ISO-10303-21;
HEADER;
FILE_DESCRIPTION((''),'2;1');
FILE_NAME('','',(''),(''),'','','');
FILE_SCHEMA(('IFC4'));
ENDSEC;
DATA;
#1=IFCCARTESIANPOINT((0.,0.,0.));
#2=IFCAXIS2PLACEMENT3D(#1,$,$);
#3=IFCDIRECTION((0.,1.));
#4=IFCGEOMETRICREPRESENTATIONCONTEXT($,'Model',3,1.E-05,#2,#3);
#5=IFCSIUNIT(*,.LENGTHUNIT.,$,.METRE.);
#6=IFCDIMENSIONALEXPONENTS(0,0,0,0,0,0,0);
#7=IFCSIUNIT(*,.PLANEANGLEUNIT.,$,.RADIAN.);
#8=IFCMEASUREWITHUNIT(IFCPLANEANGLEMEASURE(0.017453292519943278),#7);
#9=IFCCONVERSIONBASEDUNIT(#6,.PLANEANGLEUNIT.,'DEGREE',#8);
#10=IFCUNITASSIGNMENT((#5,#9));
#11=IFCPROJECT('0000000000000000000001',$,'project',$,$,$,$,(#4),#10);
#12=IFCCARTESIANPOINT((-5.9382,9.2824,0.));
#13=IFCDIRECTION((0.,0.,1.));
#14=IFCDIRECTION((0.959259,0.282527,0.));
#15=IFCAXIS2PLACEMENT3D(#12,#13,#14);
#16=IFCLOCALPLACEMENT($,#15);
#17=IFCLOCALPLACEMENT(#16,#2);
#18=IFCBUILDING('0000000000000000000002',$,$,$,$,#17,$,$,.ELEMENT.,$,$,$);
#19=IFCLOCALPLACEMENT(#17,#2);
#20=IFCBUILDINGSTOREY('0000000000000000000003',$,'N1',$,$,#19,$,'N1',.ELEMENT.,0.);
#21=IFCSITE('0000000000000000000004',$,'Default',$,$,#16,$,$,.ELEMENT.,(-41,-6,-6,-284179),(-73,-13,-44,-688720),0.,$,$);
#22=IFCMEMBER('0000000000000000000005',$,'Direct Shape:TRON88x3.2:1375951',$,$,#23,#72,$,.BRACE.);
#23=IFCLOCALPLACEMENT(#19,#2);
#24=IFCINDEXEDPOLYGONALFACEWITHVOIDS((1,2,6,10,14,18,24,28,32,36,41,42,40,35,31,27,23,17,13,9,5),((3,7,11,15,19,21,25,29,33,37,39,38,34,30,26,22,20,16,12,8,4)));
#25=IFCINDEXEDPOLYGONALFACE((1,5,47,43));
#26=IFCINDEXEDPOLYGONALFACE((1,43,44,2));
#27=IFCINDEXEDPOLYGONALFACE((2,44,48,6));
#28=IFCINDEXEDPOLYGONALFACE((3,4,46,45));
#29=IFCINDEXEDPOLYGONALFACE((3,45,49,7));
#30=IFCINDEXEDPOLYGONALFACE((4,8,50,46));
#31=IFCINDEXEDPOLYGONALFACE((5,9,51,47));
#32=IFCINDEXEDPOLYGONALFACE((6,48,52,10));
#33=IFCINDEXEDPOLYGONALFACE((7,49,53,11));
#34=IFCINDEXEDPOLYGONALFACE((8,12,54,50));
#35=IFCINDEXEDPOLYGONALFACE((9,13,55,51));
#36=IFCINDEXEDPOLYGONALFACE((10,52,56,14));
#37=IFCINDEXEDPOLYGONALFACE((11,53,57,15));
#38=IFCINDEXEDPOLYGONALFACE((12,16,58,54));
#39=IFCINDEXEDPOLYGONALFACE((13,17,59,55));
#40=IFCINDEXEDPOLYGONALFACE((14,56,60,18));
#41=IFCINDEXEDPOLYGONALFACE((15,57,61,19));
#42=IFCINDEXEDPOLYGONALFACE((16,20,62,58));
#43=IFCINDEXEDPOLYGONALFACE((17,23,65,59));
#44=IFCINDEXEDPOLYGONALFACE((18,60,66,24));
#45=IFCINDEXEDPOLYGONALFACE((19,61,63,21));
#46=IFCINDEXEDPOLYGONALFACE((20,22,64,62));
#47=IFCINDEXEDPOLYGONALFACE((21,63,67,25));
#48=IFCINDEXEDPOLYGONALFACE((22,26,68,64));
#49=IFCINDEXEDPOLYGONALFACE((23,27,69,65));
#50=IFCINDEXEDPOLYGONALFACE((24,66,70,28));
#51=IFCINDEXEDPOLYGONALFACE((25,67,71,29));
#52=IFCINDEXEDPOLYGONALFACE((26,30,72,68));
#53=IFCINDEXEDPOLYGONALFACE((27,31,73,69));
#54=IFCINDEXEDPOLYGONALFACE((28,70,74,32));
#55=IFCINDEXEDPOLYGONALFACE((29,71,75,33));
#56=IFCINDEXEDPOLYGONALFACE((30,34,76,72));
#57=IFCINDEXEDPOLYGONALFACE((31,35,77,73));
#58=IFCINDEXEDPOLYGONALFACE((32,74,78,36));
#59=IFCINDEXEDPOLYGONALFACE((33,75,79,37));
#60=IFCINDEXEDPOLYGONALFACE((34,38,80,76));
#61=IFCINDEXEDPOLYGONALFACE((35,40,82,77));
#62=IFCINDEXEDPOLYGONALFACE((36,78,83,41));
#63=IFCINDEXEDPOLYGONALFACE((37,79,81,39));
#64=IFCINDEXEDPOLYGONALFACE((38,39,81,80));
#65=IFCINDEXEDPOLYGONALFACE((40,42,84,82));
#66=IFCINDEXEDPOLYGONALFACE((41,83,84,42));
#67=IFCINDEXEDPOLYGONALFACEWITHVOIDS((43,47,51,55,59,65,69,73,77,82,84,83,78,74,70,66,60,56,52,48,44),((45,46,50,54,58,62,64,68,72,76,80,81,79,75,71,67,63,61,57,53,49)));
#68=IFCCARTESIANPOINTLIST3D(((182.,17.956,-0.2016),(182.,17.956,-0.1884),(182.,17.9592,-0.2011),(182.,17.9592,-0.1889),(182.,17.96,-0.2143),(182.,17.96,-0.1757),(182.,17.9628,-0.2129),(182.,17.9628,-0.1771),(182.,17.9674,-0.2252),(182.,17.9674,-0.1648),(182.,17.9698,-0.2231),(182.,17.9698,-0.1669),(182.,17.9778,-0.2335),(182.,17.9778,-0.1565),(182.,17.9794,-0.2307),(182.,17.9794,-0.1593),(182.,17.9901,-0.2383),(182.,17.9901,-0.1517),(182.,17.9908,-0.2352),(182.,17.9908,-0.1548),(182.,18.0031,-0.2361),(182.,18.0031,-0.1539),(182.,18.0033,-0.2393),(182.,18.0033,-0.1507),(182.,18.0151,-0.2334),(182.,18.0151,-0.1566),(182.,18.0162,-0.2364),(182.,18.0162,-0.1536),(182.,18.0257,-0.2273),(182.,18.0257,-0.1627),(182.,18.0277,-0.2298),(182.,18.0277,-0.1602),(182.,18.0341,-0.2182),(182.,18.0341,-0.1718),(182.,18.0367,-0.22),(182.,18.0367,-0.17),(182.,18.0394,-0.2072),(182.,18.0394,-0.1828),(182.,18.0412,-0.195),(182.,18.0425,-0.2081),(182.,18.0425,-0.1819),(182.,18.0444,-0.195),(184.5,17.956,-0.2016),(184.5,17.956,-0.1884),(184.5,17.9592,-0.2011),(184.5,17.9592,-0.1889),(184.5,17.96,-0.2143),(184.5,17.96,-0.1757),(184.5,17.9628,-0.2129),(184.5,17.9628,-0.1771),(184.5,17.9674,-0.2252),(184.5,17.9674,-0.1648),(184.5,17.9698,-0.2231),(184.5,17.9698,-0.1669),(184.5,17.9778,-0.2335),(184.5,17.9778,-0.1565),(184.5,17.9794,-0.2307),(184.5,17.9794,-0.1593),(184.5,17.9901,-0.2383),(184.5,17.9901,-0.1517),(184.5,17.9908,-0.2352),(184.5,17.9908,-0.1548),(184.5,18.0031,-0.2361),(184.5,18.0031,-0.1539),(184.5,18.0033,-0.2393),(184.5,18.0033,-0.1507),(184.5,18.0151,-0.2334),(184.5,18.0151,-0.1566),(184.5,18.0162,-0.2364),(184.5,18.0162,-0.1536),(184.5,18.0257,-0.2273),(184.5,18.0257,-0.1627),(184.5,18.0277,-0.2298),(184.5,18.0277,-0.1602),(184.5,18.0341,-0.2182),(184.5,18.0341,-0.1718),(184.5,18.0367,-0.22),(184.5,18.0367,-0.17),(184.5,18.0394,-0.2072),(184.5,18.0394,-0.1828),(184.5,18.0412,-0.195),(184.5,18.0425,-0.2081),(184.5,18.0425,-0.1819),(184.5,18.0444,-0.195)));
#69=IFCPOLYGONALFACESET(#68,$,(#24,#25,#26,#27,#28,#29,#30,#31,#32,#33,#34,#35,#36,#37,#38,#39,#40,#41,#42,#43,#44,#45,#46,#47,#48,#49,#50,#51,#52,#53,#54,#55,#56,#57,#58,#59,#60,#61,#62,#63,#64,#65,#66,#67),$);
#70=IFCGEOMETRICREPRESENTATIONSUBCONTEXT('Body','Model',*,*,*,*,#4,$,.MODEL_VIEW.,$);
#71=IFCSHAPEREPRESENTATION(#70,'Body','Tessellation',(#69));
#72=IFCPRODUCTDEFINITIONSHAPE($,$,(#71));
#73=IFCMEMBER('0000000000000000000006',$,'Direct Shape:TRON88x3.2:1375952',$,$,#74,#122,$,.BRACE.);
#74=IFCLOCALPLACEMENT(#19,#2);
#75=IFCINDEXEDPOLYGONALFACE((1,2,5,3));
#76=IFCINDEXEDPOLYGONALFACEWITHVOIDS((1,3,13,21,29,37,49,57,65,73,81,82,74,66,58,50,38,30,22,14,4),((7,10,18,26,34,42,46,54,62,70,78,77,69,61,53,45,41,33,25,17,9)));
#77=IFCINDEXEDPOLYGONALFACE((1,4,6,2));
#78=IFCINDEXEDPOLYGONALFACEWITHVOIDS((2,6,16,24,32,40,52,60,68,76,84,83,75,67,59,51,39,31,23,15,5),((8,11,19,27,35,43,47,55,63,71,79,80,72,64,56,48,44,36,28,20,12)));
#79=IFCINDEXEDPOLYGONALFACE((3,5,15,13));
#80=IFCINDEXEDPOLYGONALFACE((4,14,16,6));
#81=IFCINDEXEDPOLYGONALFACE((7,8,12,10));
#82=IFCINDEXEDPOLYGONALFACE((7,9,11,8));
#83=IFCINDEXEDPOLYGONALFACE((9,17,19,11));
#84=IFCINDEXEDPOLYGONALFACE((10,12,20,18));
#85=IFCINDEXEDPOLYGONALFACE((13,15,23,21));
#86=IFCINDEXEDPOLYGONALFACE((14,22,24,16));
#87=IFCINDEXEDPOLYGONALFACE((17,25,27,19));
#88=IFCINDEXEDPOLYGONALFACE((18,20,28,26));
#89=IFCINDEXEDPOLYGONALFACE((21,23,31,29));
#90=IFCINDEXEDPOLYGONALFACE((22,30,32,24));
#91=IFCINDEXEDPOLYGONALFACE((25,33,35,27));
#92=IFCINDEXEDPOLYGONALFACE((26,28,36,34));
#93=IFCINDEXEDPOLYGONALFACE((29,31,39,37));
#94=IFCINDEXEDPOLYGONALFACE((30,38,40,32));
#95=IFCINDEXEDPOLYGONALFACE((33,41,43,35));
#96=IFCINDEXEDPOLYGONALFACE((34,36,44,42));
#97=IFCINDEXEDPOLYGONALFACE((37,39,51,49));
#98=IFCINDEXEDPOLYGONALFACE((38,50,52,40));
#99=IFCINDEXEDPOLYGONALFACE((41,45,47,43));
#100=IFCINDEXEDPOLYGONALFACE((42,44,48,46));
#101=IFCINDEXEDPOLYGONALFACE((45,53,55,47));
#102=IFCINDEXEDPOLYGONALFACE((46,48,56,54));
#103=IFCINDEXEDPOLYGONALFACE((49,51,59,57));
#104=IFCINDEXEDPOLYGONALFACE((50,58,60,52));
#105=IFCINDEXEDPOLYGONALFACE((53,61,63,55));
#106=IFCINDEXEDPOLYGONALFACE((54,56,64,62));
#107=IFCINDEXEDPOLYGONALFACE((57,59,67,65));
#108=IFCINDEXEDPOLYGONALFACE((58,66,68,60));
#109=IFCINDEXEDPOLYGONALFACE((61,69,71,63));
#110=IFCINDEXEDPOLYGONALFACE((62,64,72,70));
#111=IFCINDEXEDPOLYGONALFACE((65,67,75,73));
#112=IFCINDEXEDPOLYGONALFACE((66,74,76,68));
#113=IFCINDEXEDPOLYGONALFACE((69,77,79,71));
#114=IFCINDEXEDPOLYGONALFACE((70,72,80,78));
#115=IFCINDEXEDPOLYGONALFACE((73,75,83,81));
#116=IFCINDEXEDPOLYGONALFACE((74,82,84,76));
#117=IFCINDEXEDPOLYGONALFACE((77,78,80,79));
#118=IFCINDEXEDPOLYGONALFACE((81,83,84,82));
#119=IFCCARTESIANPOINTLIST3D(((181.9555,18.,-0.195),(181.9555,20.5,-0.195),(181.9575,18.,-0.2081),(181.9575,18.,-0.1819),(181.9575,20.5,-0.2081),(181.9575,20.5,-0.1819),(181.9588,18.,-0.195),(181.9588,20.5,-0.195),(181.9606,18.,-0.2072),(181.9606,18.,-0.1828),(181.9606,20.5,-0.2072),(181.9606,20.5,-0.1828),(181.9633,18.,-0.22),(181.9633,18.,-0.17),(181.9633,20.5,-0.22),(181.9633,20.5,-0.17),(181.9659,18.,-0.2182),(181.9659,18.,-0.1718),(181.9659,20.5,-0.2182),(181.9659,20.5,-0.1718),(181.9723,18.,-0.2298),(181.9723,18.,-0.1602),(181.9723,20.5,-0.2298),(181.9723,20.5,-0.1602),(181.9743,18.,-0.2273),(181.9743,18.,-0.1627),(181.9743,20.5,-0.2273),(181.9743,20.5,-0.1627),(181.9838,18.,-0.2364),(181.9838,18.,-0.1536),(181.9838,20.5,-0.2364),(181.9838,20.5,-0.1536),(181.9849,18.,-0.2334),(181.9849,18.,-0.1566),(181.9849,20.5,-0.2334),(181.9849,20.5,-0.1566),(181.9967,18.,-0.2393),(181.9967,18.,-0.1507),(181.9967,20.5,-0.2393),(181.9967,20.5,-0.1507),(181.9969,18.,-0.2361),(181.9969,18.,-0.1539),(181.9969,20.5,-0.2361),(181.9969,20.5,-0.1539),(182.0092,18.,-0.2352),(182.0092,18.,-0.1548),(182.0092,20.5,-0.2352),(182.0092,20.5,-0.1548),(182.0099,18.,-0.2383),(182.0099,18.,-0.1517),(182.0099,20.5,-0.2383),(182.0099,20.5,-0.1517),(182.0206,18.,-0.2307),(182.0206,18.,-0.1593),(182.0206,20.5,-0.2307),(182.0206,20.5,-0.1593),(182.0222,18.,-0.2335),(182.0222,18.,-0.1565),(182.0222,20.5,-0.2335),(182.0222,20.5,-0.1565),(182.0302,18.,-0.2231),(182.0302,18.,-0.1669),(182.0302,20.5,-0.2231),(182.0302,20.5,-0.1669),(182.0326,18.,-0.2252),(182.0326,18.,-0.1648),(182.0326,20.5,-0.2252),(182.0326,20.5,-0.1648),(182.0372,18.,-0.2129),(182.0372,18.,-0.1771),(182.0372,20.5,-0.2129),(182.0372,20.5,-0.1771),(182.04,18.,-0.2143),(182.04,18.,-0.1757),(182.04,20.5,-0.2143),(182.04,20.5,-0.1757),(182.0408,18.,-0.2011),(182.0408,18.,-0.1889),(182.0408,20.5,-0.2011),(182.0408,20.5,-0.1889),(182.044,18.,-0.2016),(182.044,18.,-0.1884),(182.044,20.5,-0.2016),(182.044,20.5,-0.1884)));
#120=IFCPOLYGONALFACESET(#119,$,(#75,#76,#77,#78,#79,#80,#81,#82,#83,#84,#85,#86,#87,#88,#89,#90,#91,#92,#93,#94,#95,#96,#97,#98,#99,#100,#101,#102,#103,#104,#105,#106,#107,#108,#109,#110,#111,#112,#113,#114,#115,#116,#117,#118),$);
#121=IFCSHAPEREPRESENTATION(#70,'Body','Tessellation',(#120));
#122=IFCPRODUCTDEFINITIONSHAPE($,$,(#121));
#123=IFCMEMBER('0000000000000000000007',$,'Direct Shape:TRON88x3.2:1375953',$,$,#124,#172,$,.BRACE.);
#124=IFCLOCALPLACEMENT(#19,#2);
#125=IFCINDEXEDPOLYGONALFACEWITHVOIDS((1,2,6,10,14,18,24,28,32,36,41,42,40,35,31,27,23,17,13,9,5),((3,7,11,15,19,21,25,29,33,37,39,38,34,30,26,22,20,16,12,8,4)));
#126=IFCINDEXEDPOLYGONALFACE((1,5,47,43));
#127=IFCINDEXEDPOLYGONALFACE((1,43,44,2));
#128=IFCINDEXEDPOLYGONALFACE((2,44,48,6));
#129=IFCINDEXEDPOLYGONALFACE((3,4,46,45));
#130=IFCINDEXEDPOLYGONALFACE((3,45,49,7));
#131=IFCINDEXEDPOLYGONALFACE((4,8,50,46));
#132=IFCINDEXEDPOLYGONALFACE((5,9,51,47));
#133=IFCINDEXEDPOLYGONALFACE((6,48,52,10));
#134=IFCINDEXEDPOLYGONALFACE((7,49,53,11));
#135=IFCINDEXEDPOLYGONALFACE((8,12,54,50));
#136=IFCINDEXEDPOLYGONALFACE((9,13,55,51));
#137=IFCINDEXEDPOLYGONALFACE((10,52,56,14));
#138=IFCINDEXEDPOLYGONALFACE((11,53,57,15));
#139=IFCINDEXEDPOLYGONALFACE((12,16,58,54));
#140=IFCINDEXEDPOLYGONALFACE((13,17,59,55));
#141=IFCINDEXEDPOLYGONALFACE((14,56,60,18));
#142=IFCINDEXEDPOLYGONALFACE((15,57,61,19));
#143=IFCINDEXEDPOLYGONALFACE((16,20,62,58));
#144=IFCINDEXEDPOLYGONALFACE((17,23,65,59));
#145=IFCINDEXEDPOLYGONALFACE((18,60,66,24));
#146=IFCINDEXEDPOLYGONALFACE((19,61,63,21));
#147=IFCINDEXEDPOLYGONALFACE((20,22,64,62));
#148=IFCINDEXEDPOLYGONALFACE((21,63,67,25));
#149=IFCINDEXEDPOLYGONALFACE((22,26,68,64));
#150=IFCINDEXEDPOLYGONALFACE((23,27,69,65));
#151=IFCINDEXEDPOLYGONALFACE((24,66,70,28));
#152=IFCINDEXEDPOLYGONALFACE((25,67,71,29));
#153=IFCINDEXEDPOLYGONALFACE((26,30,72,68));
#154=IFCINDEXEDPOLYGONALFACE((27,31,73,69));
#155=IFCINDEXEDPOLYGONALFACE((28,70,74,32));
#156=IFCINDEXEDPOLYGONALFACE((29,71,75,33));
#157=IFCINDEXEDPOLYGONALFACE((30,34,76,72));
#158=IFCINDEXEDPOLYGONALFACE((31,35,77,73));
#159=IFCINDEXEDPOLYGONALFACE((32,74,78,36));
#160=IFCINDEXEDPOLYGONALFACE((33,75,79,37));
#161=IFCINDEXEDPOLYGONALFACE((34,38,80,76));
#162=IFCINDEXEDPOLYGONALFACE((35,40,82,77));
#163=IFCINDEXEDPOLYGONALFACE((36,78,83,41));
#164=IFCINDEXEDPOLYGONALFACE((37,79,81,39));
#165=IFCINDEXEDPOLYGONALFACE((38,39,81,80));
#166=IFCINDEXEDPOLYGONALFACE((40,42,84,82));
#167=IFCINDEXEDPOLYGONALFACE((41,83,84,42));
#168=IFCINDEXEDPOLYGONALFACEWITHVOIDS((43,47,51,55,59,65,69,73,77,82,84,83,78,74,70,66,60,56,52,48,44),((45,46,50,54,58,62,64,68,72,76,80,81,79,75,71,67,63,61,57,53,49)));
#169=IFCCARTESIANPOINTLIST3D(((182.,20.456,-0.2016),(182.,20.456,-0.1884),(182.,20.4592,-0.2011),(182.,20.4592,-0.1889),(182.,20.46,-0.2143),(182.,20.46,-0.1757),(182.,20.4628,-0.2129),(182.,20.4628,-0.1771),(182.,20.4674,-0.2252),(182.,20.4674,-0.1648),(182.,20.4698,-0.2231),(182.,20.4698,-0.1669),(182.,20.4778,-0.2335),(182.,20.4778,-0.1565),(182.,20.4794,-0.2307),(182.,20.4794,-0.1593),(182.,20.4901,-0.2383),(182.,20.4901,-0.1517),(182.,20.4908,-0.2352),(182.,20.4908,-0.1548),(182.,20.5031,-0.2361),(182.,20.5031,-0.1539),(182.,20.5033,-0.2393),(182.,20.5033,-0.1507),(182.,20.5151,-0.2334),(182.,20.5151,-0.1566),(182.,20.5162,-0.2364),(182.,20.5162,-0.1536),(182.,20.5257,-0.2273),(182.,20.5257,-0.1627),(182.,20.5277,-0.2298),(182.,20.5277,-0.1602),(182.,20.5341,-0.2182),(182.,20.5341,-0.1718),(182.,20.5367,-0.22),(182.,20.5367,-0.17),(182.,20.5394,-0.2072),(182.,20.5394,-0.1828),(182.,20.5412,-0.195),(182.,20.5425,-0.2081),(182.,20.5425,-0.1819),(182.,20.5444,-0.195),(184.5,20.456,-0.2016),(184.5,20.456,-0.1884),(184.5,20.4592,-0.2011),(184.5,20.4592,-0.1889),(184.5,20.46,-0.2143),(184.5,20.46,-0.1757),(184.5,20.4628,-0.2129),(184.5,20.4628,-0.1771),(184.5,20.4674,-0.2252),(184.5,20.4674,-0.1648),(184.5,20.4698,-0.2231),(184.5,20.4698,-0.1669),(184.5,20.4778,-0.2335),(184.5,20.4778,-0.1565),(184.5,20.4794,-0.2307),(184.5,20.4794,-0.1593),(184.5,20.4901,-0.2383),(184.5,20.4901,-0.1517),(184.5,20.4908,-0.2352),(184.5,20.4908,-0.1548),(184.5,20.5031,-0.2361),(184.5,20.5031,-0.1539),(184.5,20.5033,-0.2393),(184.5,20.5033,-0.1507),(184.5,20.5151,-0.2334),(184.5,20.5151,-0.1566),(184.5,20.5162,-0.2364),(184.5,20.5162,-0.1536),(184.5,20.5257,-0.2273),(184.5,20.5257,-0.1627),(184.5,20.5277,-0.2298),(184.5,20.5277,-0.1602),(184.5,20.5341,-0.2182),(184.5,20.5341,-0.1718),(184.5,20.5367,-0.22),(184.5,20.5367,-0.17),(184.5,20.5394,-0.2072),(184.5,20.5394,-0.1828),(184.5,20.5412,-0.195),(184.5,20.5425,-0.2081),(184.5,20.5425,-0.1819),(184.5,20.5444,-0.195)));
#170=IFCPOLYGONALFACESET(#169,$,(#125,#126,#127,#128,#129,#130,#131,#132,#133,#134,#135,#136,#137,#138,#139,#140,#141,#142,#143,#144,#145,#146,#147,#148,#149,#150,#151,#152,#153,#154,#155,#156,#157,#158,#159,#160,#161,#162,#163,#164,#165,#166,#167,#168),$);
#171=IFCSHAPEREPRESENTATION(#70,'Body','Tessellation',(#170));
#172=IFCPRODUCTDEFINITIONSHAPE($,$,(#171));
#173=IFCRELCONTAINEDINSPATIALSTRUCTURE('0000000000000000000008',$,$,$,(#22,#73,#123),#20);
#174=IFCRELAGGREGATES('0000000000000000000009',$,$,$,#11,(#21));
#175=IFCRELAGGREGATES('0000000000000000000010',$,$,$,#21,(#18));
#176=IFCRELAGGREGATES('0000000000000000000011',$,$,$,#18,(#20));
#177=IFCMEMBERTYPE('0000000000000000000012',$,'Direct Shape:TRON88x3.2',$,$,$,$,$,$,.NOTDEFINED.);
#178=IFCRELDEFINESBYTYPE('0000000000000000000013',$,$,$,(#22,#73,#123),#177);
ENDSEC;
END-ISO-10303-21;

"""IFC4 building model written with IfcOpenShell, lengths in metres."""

from ifc_helpers import new_model, entity, si_unit, converted_unit, direction, frame, frame_2d, origin, place, context, subcontext, project, spatial, hollow_circle, extrude, type_object, element, save


model = new_model("IFC4")

# Units and contexts
model_context = context("Model", 3, precision=1e-05, world=origin(), true_north=direction((0.0, 1.0)))
body_context = subcontext(model_context, "Body", "Model", "MODEL_VIEW")
ifc_project = project(units=[si_unit("LENGTHUNIT", "METRE"), converted_unit("PLANEANGLEUNIT", "DEGREE", entity("IfcPlaneAngleMeasure", 0.017453292519943278), si_unit("PLANEANGLEUNIT", "RADIAN"), dimensions=[0, 0, 0, 0, 0, 0, 0])], contexts=[model_context])

# Site, building, storey
site_placement = place(None, frame((-5.9382, 9.2824, 0.0), z_axis=(0.0, 0.0, 1.0), x_axis=(0.959259, 0.282527, 0.0)))
site = spatial("IfcSite", under=ifc_project, at=site_placement, Name="Default", CompositionType="ELEMENT", RefLatitude=(-41, -6, -6, -284179), RefLongitude=(-73, -13, -44, -688720), RefElevation=0.0)
building_placement = place(site_placement, origin())
building = spatial("IfcBuilding", under=site, at=building_placement, CompositionType="ELEMENT")
storey_placement = place(building_placement, origin())
storey = spatial("IfcBuildingStorey", under=building, at=storey_placement, Name="N1", LongName="N1", CompositionType="ELEMENT", Elevation=0.0)

# Members
member_type_1 = type_object("IfcMemberType", Name="Direct Shape:TRON88x3.2", PredefinedType="NOTDEFINED")
member_1_placement = place(storey_placement, origin())
element("IfcMember", 1, at=member_1_placement, inside=storey, type_object=member_type_1, Name="Direct Shape:TRON88x3.2:1375951", PredefinedType="BRACE", context=body_context, shape_type="SweptSolid", body=[
    extrude(hollow_circle(Radius=0.0445, WallThickness=0.0032, at=frame_2d((0.0, 0.0), x_axis=(1.0, 0.0))), frame((182.0, 18.0, -0.195), z_axis=(1.0, 0.0, 0.0), x_axis=(0.0, 1.0, 0.0)), (0.0, 0.0, 1.0), 2.5),
])
member_2_placement = place(storey_placement, origin())
element("IfcMember", 2, at=member_2_placement, inside=storey, type_object=member_type_1, Name="Direct Shape:TRON88x3.2:1375952", PredefinedType="BRACE", context=body_context, shape_type="SweptSolid", body=[
    extrude(hollow_circle(Radius=0.0445, WallThickness=0.0032, at=frame_2d((0.0, 0.0), x_axis=(1.0, 0.0))), frame((182.0, 18.0, -0.195), z_axis=(0.0, 1.0, 0.0), x_axis=(-1.0, 0.0, 0.0)), (0.0, 0.0, 1.0), 2.5),
])
member_3_placement = place(storey_placement, origin())
element("IfcMember", 3, at=member_3_placement, inside=storey, type_object=member_type_1, Name="Direct Shape:TRON88x3.2:1375953", PredefinedType="BRACE", context=body_context, shape_type="SweptSolid", body=[
    extrude(hollow_circle(Radius=0.0445, WallThickness=0.0032, at=frame_2d((0.0, 0.0), x_axis=(1.0, 0.0))), frame((182.0, 20.5, -0.195), z_axis=(1.0, 0.0, 0.0), x_axis=(0.0, 1.0, 0.0)), (0.0, 0.0, 1.0), 2.5),
])

save(model, "model.ifc")
